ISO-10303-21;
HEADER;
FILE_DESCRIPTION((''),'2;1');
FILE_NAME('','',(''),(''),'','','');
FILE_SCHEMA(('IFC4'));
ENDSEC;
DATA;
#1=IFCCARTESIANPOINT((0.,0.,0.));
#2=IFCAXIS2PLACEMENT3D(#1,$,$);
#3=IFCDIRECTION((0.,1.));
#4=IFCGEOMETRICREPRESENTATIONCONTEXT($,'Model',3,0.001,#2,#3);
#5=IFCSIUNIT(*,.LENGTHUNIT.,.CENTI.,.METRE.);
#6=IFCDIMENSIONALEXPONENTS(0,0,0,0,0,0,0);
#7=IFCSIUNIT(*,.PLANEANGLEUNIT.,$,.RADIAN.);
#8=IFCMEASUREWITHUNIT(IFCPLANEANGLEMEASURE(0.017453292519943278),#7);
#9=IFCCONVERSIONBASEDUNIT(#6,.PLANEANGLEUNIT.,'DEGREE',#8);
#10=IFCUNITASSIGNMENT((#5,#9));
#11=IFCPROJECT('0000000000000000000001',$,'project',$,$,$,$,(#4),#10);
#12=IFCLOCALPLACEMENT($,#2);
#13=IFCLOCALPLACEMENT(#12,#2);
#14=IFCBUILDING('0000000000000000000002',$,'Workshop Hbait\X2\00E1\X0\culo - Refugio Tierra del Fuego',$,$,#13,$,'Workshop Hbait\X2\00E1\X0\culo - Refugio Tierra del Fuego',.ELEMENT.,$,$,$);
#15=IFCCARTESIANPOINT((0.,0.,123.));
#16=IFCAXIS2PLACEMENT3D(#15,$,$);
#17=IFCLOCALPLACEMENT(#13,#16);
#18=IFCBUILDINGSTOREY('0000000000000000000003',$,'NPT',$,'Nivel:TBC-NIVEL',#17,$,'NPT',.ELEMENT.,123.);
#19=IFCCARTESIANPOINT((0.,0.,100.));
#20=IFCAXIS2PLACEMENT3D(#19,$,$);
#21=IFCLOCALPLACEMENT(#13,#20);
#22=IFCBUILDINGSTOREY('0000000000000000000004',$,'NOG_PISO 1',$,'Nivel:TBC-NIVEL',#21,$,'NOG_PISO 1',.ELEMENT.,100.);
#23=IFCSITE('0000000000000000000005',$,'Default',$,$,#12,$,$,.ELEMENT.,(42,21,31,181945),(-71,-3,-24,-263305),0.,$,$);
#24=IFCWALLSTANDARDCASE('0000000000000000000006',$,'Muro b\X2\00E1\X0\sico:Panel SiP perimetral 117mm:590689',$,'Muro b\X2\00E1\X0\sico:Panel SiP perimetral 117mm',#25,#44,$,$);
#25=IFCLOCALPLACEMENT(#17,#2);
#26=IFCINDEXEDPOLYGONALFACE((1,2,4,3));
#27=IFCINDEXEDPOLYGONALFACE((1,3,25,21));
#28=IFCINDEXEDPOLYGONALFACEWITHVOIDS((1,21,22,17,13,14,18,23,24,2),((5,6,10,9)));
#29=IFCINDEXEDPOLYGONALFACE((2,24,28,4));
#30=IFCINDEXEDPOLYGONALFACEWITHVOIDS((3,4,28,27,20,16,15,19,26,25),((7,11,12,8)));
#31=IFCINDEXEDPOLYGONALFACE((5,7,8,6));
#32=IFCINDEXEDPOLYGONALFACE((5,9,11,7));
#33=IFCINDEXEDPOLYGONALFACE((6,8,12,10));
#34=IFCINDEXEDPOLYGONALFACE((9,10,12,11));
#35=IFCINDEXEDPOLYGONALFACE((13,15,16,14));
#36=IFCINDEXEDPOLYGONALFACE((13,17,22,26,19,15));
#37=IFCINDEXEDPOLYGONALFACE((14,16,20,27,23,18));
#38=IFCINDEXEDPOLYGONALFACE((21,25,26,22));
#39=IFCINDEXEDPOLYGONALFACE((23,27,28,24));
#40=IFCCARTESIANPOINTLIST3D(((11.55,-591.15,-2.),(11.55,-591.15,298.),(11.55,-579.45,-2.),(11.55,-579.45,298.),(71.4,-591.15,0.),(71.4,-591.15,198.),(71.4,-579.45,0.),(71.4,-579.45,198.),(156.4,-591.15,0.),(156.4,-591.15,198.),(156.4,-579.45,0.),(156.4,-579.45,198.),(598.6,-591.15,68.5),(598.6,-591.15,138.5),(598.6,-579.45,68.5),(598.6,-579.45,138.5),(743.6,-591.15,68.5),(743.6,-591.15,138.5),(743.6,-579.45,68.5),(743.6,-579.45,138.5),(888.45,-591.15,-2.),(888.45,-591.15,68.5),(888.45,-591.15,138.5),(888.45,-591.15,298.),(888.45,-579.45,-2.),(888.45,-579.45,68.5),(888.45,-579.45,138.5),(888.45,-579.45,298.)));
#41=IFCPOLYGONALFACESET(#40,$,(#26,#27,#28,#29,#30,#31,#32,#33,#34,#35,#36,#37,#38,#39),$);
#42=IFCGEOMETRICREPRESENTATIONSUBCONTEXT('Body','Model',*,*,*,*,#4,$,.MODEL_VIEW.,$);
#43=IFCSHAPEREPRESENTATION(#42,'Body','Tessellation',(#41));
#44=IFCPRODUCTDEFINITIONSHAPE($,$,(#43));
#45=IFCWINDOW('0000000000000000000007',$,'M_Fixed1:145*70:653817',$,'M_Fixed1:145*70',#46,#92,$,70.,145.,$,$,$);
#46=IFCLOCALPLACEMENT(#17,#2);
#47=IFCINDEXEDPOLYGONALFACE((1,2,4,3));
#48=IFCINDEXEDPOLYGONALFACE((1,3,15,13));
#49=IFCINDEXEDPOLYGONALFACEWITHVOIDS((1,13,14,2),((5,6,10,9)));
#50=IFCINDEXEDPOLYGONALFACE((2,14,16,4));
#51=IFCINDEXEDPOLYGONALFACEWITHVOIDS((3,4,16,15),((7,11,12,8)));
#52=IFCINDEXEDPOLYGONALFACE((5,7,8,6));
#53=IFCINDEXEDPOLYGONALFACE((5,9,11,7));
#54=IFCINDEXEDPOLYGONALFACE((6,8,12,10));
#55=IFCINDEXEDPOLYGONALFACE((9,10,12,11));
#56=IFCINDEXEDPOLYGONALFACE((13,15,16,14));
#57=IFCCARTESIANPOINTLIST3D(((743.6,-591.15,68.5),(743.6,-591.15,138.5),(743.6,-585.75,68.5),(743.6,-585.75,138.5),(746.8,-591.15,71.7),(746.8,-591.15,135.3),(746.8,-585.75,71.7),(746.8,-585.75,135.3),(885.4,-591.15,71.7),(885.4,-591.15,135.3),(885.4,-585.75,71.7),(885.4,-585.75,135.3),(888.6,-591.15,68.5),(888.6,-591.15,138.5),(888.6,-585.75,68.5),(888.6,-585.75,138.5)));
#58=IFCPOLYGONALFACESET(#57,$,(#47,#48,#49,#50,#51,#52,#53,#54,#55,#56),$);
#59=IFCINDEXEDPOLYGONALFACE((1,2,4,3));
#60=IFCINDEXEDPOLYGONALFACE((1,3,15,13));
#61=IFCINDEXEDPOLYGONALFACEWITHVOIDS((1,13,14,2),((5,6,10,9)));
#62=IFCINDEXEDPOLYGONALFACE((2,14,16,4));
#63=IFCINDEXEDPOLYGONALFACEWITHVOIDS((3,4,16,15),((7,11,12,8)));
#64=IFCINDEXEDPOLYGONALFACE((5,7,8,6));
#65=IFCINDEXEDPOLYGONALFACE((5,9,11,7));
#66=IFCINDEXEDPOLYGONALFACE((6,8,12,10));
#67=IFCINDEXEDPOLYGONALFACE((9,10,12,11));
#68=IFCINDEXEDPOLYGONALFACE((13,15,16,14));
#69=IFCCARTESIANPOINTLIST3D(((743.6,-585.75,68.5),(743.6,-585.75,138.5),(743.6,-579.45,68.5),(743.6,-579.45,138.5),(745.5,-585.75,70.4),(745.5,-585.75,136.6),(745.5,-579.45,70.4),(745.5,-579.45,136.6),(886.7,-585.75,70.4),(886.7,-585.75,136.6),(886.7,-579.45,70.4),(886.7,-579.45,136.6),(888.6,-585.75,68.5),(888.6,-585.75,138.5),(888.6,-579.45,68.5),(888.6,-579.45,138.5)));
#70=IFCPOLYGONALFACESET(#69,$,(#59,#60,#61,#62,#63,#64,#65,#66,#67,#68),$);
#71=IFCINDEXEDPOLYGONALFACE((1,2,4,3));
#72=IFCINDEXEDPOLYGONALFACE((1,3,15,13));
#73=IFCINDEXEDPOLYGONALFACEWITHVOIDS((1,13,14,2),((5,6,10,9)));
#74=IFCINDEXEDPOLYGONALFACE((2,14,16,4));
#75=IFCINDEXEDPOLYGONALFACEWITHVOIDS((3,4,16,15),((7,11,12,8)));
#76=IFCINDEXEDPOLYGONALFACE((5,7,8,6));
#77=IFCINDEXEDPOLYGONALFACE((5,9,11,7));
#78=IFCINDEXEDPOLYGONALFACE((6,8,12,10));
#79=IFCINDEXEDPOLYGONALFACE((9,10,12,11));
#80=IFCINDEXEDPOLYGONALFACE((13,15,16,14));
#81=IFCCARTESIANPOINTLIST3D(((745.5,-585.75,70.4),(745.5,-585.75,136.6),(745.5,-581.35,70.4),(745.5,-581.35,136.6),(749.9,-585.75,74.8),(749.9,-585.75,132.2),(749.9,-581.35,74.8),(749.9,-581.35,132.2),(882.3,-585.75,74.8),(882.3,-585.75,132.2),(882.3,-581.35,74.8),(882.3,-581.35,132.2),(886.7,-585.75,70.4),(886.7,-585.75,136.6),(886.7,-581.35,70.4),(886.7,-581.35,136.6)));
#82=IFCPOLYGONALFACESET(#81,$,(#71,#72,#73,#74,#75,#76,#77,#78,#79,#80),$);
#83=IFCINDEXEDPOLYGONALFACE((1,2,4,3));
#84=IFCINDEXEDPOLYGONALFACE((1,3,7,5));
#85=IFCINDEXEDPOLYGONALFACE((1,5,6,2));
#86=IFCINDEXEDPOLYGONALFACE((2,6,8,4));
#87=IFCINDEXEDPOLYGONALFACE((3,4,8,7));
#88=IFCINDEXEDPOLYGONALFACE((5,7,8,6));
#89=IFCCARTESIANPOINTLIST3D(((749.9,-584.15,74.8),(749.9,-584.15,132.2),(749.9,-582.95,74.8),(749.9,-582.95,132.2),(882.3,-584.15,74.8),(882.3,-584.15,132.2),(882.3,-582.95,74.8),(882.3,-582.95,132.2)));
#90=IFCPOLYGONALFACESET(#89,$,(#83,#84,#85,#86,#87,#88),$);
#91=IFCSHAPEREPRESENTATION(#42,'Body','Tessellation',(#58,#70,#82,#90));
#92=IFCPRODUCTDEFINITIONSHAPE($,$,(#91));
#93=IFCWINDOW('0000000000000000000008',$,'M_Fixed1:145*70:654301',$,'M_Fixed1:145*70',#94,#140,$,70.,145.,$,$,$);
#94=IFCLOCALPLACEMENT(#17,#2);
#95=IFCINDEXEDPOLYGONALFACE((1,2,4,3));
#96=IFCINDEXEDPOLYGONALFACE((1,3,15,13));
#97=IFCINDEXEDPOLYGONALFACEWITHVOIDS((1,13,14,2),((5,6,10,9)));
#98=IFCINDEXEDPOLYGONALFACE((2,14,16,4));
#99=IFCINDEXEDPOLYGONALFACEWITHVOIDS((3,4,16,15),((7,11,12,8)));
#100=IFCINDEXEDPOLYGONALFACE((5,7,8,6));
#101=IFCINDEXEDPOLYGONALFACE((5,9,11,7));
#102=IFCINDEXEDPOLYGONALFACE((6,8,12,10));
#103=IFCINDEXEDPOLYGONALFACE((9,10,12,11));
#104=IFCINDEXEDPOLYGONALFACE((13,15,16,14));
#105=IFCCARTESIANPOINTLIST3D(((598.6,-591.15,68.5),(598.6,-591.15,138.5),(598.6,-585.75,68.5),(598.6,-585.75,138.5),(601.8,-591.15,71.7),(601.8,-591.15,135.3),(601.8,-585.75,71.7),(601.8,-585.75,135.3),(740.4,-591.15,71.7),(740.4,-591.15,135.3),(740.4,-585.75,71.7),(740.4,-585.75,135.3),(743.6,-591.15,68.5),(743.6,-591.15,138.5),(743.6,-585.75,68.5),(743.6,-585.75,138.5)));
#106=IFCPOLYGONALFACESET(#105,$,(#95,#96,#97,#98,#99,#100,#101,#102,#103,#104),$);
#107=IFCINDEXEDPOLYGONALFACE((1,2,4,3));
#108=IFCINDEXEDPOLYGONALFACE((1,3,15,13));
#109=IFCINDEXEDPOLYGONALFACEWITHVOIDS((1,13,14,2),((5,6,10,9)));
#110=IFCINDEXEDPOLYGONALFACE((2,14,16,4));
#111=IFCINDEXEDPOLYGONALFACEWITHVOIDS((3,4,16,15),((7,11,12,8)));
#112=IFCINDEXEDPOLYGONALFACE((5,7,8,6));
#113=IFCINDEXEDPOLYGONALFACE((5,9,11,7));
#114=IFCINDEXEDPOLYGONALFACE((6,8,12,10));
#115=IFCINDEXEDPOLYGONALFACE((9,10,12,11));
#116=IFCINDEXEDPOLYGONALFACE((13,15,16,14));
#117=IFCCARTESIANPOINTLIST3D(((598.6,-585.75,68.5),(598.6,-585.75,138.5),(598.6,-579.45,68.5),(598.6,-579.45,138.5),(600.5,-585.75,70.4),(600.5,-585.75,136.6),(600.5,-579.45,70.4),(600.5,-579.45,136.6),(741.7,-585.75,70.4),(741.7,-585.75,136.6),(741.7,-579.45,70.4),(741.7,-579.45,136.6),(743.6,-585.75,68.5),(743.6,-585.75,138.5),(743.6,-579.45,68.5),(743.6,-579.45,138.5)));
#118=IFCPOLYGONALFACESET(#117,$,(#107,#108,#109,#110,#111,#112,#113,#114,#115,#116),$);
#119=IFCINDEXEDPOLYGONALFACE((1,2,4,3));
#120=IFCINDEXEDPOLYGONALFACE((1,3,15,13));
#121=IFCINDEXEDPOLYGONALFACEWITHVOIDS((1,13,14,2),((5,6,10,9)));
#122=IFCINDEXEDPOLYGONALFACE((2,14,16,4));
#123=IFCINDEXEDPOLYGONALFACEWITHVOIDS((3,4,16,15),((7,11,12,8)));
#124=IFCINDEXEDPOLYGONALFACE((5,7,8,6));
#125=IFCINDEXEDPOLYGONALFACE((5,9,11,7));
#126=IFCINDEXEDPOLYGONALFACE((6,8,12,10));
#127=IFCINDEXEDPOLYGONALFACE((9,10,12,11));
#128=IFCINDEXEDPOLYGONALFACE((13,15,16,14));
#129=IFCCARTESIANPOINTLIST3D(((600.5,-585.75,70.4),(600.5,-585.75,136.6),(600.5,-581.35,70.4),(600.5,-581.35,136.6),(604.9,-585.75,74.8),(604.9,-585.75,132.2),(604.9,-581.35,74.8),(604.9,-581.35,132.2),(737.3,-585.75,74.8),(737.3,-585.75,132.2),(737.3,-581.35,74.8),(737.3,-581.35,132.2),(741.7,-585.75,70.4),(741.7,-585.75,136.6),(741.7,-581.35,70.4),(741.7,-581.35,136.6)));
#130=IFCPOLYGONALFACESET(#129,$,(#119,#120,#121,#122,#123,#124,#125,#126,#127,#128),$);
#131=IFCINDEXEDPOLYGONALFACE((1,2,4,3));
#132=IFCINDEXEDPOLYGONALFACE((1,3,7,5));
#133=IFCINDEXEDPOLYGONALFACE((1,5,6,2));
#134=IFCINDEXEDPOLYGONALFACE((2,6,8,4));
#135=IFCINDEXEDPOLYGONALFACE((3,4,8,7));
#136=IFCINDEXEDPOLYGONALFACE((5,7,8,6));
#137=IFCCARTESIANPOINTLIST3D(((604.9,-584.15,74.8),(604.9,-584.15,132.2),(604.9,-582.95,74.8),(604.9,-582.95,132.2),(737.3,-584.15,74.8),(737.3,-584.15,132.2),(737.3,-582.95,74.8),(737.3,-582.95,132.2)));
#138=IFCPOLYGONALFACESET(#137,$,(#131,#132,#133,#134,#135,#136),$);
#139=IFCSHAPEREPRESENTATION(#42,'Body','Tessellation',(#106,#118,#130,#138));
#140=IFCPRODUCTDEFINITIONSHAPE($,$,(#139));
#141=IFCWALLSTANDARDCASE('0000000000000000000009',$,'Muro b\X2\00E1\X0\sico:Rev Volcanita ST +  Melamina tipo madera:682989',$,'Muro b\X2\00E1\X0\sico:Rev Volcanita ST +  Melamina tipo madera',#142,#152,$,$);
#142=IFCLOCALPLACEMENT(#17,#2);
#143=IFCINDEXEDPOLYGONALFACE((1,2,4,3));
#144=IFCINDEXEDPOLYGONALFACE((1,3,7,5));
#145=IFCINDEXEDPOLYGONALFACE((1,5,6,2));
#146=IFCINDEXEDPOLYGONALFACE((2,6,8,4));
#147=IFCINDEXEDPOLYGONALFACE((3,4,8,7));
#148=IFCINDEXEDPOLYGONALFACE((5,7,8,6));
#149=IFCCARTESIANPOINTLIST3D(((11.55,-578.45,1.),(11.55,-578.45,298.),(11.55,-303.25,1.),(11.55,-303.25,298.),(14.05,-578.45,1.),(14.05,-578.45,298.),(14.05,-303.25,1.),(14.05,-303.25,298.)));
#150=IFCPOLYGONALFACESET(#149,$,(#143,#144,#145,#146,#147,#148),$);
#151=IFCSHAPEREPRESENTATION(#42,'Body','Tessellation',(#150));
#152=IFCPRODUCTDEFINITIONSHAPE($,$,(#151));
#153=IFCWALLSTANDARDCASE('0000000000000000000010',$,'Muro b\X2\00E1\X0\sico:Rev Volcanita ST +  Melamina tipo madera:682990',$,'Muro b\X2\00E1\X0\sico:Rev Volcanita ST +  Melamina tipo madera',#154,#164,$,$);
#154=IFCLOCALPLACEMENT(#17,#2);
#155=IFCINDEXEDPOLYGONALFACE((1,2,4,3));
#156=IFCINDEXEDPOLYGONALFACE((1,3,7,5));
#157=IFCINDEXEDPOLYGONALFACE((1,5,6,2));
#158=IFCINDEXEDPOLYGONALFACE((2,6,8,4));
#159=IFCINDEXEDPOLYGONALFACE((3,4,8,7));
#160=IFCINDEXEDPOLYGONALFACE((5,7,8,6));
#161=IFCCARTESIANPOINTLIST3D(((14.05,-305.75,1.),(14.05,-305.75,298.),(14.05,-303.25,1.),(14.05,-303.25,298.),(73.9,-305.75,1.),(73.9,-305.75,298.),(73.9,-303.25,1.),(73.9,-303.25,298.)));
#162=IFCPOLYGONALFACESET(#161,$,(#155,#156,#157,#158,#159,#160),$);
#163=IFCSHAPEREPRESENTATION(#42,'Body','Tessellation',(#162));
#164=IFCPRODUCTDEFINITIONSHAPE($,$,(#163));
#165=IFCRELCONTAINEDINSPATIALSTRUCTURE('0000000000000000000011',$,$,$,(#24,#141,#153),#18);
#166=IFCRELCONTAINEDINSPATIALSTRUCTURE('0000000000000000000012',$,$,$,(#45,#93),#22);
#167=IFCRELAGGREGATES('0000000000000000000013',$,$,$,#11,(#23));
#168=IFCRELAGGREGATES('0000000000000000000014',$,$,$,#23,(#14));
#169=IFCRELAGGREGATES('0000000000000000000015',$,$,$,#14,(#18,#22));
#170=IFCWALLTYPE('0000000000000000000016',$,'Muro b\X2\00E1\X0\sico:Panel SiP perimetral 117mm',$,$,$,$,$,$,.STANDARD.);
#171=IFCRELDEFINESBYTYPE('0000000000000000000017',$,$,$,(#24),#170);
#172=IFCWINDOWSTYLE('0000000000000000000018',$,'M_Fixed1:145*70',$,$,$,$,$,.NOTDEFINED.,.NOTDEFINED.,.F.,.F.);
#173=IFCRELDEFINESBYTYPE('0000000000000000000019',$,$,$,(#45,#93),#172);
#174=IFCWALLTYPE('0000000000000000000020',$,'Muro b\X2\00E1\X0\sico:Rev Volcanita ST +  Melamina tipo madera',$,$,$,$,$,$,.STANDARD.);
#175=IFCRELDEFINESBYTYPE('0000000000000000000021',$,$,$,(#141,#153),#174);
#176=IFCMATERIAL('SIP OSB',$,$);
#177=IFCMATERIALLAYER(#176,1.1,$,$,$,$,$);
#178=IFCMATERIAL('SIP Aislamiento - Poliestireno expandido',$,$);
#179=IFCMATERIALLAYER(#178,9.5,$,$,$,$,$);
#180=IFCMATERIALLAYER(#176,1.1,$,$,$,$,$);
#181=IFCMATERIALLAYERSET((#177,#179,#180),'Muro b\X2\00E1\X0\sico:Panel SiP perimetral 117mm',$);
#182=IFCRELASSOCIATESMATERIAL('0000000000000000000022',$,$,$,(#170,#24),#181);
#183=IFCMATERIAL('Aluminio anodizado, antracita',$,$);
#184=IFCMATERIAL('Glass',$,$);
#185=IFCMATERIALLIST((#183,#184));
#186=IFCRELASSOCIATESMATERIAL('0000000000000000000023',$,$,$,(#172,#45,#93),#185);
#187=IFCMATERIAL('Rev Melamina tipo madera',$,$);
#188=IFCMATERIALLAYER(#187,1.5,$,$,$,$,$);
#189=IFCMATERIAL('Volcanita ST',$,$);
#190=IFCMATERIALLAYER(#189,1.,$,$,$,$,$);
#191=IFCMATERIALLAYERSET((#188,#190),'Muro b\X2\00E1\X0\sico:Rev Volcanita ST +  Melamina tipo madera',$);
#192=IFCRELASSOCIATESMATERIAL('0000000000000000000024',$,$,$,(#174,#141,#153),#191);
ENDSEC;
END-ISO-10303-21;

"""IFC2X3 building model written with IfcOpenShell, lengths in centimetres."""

from ifc_helpers import new_model, entity, si_unit, converted_unit, direction, frame, frame_2d, origin, origin_2d_with_axis, place, context, subcontext, project, spatial, polyline, rectangle, outline, extrude, source, transform, mapped, material, material_list, layer, layer_set, layer_usage, type_object, type_shapes, element, fill, save


model = new_model("IFC2X3")

# Units and contexts
model_context = context("Model", 3, precision=0.001, world=origin(), true_north=direction((0.0, 1.0)))
body_context = subcontext(model_context, "Body", "Model", "MODEL_VIEW")
ifc_project = project(units=[si_unit("LENGTHUNIT", "METRE", prefix="CENTI"), converted_unit("PLANEANGLEUNIT", "DEGREE", entity("IfcPlaneAngleMeasure", 0.017453292519943278), si_unit("PLANEANGLEUNIT", "RADIAN"), dimensions=[0, 0, 0, 0, 0, 0, 0])], contexts=[model_context])

# Site, building, storey
site_placement = place(None, origin())
site = spatial("IfcSite", under=ifc_project, at=site_placement, Name="Default", CompositionType="ELEMENT", RefLatitude=(42, 21, 31, 181945), RefLongitude=(-71, -3, -24, -263305), RefElevation=0.0)
building_placement = place(site_placement, origin())
building = spatial("IfcBuilding", under=site, at=building_placement, Name="Workshop Hbaitáculo - Refugio Tierra del Fuego", LongName="Workshop Hbaitáculo - Refugio Tierra del Fuego", CompositionType="ELEMENT")
storey_1_placement = place(building_placement, frame((0.0, 0.0, 123.0)))
storey_1 = spatial("IfcBuildingStorey", under=building, at=storey_1_placement, Name="NPT", ObjectType="Nivel:TBC-NIVEL", LongName="NPT", CompositionType="ELEMENT", Elevation=123.0)

# Wall, openings
ifc_material_1 = material(Name="SIP OSB")
ifc_layer_1 = layer(ifc_material_1, 1.1)
ifc_material_2 = material(Name="SIP Aislamiento - Poliestireno expandido")
ifc_layer_2 = layer(ifc_material_2, 9.5)
ifc_layer_3 = layer(ifc_material_1, 1.1)
ifc_layer_set_1 = layer_set([ifc_layer_1, ifc_layer_2, ifc_layer_3], Name="Muro básico:Panel SiP perimetral 117mm")
ifc_layer_usage_1 = layer_usage(ifc_layer_set_1, "AXIS2", "POSITIVE", -5.85)
wall_type_1 = type_object("IfcWallType", Name="Muro básico:Panel SiP perimetral 117mm", PredefinedType="STANDARD", material=ifc_layer_set_1)
wall_1_placement = place(storey_1_placement, frame((11.55, -585.3, -2.0)))
wall_1 = element("IfcWallStandardCase", 1, at=wall_1_placement, inside=storey_1, type_object=wall_type_1, material=ifc_layer_usage_1, Name="Muro básico:Panel SiP perimetral 117mm:590689", ObjectType="Muro básico:Panel SiP perimetral 117mm", context=body_context, shape_type="SweptSolid", body=[
    extrude(rectangle(XDim=876.9, YDim=11.7, at=frame_2d((438.45, 0.0), x_axis=(-1.0, 0.0))), origin(), (0.0, 0.0, 1.0), 300.0),
])
opening_1_placement = place(wall_1_placement, frame((732.05, -5.85, 70.5)))
opening_1 = element("IfcOpeningElement", 2, at=opening_1_placement, cuts=wall_1, ObjectType="Opening", context=body_context, shape_type="SweptSolid", body=[
    extrude(rectangle(XDim=70.0, YDim=145.0, at=frame_2d((35.0, 72.5), x_axis=(1.0, 0.0))), frame((0.0, 0.0, 0.0), z_axis=(0.0, 1.0, 0.0), x_axis=(0.0, 0.0, 1.0)), (0.0, 0.0, 1.0), 11.7),
])
opening_2_placement = place(wall_1_placement, frame((587.05, -5.85, 70.5)))
opening_2 = element("IfcOpeningElement", 3, at=opening_2_placement, cuts=wall_1, ObjectType="Opening", context=body_context, shape_type="SweptSolid", body=[
    extrude(rectangle(XDim=70.0, YDim=145.0, at=frame_2d((35.0, 72.5), x_axis=(1.0, 0.0))), frame((0.0, 0.0, 0.0), z_axis=(0.0, 1.0, 0.0), x_axis=(0.0, 0.0, 1.0)), (0.0, 0.0, 1.0), 11.7),
])
opening_3_placement = place(wall_1_placement, frame((59.85, -5.85, 2.0)))
element("IfcOpeningElement", 4, at=opening_3_placement, cuts=wall_1, ObjectType="Opening", context=body_context, shape_type="SweptSolid", body=[
    extrude(rectangle(XDim=198.0, YDim=85.0, at=frame_2d((99.0, 42.5), x_axis=(1.0, 0.0))), frame((0.0, 0.0, 0.0), z_axis=(0.0, 1.0, 0.0), x_axis=(0.0, 0.0, 1.0)), (0.0, 0.0, 1.0), 11.7),
])

# Shared definitions
storey_2_placement = place(building_placement, frame((0.0, 0.0, 100.0)))
storey_2 = spatial("IfcBuildingStorey", under=building, at=storey_2_placement, Name="NOG_PISO 1", ObjectType="Nivel:TBC-NIVEL", LongName="NOG_PISO 1", CompositionType="ELEMENT", Elevation=100.0)

# Windows
ifc_material_3 = material(Name="Aluminio anodizado, antracita")
ifc_material_4 = material(Name="Glass")
ifc_material_list = material_list([ifc_material_3, ifc_material_4])
window_style = type_object("IfcWindowStyle", Name="M_Fixed1:145*70", ConstructionType="NOTDEFINED", OperationType="NOTDEFINED", ParameterTakesPrecedence=False, Sizeable=False, material=ifc_material_list)
shared_shape_1 = source(origin(), body_context, "Body", "SweptSolid", [
    extrude(outline(polyline([(-72.5, -35.0), (72.5, -35.0), (72.5, 35.0), (-72.5, 35.0), (-72.5, -35.0)]), holes=[polyline([(-69.3, -31.8), (-69.3, 31.8), (69.3, 31.8), (69.3, -31.8), (-69.3, -31.8)])]), frame((72.5, 0.0, 35.0), z_axis=(0.0, 1.0, 0.0), x_axis=(1.0, 0.0, 0.0)), (0.0, 0.0, 1.0), 5.4),
    extrude(outline(polyline([(-72.5, -35.0), (72.5, -35.0), (72.5, 35.0), (-72.5, 35.0), (-72.5, -35.0)]), holes=[polyline([(-70.6, -33.1), (-70.6, 33.1), (70.6, 33.1), (70.6, -33.1), (-70.6, -33.1)])]), frame((72.5, 5.4, 35.0), z_axis=(0.0, 1.0, 0.0), x_axis=(1.0, 0.0, 0.0)), (0.0, 0.0, 1.0), 6.3),
    extrude(outline(polyline([(-70.6, -33.1), (70.6, -33.1), (70.6, 33.1), (-70.6, 33.1), (-70.6, -33.1)]), holes=[polyline([(-66.2, -28.7), (-66.2, 28.7), (66.2, 28.7), (66.2, -28.7), (-66.2, -28.7)])]), frame((72.5, 5.4, 35.0), z_axis=(0.0, 1.0, 0.0), x_axis=(1.0, 0.0, 0.0)), (0.0, 0.0, 1.0), 4.4),
    extrude(rectangle(XDim=1.2, YDim=132.4, at=origin_2d_with_axis()), frame((72.5, 7.6, 6.3), z_axis=(0.0, 0.0, 1.0), x_axis=(0.0, -1.0, 0.0)), (0.0, 0.0, 1.0), 57.4),
])
type_shapes(window_style, [shared_shape_1])
window_1_placement = place(opening_1_placement, origin())
window_1 = element("IfcWindow", 5, at=window_1_placement, inside=storey_2, type_object=window_style, material=ifc_material_list, Name="M_Fixed1:145*70:653817", ObjectType="M_Fixed1:145*70", OverallHeight=70.0, OverallWidth=145.0, context=body_context, shape_type="MappedRepresentation", body=[
    mapped(shared_shape_1, transform((0.0, 0.0, 0.0), scale=1.0)),
])
fill(opening_1, window_1)
window_2_placement = place(opening_2_placement, origin())
window_2 = element("IfcWindow", 6, at=window_2_placement, inside=storey_2, type_object=window_style, material=ifc_material_list, Name="M_Fixed1:145*70:654301", ObjectType="M_Fixed1:145*70", OverallHeight=70.0, OverallWidth=145.0, context=body_context, shape_type="MappedRepresentation", body=[
    mapped(shared_shape_1, transform((0.0, 0.0, 0.0), scale=1.0)),
])
fill(opening_2, window_2)

# Walls
ifc_material_5 = material(Name="Rev Melamina tipo madera")
ifc_layer_4 = layer(ifc_material_5, 1.5)
ifc_material_6 = material(Name="Volcanita ST")
ifc_layer_5 = layer(ifc_material_6, 1.0)
ifc_layer_set_2 = layer_set([ifc_layer_4, ifc_layer_5], Name="Muro básico:Rev Volcanita ST +  Melamina tipo madera")
ifc_layer_usage_2 = layer_usage(ifc_layer_set_2, "AXIS2", "POSITIVE", -1.25)
wall_type_2 = type_object("IfcWallType", Name="Muro básico:Rev Volcanita ST +  Melamina tipo madera", PredefinedType="STANDARD", material=ifc_layer_set_2)
wall_2_placement = place(storey_1_placement, frame((12.8, -578.45, 1.0), z_axis=(0.0, 0.0, 1.0), x_axis=(0.0, 1.0, 0.0)))
element("IfcWallStandardCase", 7, at=wall_2_placement, inside=storey_1, type_object=wall_type_2, material=ifc_layer_usage_2, Name="Muro básico:Rev Volcanita ST +  Melamina tipo madera:682989", ObjectType="Muro básico:Rev Volcanita ST +  Melamina tipo madera", context=body_context, shape_type="SweptSolid", body=[
    extrude(rectangle(XDim=275.2, YDim=2.5, at=frame_2d((137.6, 0.0), x_axis=(-1.0, 0.0))), origin(), (0.0, 0.0, 1.0), 297.0),
])
ifc_layer_usage_3 = layer_usage(ifc_layer_set_2, "AXIS2", "POSITIVE", -1.25)
wall_3_placement = place(storey_1_placement, frame((14.05, -304.5, 1.0)))
element("IfcWallStandardCase", 8, at=wall_3_placement, inside=storey_1, type_object=wall_type_2, material=ifc_layer_usage_3, Name="Muro básico:Rev Volcanita ST +  Melamina tipo madera:682990", ObjectType="Muro básico:Rev Volcanita ST +  Melamina tipo madera", context=body_context, shape_type="SweptSolid", body=[
    extrude(rectangle(XDim=59.85, YDim=2.5, at=frame_2d((29.92, 0.0), x_axis=(-1.0, 0.0))), origin(), (0.0, 0.0, 1.0), 297.0),
])

save(model, "model.ifc")
